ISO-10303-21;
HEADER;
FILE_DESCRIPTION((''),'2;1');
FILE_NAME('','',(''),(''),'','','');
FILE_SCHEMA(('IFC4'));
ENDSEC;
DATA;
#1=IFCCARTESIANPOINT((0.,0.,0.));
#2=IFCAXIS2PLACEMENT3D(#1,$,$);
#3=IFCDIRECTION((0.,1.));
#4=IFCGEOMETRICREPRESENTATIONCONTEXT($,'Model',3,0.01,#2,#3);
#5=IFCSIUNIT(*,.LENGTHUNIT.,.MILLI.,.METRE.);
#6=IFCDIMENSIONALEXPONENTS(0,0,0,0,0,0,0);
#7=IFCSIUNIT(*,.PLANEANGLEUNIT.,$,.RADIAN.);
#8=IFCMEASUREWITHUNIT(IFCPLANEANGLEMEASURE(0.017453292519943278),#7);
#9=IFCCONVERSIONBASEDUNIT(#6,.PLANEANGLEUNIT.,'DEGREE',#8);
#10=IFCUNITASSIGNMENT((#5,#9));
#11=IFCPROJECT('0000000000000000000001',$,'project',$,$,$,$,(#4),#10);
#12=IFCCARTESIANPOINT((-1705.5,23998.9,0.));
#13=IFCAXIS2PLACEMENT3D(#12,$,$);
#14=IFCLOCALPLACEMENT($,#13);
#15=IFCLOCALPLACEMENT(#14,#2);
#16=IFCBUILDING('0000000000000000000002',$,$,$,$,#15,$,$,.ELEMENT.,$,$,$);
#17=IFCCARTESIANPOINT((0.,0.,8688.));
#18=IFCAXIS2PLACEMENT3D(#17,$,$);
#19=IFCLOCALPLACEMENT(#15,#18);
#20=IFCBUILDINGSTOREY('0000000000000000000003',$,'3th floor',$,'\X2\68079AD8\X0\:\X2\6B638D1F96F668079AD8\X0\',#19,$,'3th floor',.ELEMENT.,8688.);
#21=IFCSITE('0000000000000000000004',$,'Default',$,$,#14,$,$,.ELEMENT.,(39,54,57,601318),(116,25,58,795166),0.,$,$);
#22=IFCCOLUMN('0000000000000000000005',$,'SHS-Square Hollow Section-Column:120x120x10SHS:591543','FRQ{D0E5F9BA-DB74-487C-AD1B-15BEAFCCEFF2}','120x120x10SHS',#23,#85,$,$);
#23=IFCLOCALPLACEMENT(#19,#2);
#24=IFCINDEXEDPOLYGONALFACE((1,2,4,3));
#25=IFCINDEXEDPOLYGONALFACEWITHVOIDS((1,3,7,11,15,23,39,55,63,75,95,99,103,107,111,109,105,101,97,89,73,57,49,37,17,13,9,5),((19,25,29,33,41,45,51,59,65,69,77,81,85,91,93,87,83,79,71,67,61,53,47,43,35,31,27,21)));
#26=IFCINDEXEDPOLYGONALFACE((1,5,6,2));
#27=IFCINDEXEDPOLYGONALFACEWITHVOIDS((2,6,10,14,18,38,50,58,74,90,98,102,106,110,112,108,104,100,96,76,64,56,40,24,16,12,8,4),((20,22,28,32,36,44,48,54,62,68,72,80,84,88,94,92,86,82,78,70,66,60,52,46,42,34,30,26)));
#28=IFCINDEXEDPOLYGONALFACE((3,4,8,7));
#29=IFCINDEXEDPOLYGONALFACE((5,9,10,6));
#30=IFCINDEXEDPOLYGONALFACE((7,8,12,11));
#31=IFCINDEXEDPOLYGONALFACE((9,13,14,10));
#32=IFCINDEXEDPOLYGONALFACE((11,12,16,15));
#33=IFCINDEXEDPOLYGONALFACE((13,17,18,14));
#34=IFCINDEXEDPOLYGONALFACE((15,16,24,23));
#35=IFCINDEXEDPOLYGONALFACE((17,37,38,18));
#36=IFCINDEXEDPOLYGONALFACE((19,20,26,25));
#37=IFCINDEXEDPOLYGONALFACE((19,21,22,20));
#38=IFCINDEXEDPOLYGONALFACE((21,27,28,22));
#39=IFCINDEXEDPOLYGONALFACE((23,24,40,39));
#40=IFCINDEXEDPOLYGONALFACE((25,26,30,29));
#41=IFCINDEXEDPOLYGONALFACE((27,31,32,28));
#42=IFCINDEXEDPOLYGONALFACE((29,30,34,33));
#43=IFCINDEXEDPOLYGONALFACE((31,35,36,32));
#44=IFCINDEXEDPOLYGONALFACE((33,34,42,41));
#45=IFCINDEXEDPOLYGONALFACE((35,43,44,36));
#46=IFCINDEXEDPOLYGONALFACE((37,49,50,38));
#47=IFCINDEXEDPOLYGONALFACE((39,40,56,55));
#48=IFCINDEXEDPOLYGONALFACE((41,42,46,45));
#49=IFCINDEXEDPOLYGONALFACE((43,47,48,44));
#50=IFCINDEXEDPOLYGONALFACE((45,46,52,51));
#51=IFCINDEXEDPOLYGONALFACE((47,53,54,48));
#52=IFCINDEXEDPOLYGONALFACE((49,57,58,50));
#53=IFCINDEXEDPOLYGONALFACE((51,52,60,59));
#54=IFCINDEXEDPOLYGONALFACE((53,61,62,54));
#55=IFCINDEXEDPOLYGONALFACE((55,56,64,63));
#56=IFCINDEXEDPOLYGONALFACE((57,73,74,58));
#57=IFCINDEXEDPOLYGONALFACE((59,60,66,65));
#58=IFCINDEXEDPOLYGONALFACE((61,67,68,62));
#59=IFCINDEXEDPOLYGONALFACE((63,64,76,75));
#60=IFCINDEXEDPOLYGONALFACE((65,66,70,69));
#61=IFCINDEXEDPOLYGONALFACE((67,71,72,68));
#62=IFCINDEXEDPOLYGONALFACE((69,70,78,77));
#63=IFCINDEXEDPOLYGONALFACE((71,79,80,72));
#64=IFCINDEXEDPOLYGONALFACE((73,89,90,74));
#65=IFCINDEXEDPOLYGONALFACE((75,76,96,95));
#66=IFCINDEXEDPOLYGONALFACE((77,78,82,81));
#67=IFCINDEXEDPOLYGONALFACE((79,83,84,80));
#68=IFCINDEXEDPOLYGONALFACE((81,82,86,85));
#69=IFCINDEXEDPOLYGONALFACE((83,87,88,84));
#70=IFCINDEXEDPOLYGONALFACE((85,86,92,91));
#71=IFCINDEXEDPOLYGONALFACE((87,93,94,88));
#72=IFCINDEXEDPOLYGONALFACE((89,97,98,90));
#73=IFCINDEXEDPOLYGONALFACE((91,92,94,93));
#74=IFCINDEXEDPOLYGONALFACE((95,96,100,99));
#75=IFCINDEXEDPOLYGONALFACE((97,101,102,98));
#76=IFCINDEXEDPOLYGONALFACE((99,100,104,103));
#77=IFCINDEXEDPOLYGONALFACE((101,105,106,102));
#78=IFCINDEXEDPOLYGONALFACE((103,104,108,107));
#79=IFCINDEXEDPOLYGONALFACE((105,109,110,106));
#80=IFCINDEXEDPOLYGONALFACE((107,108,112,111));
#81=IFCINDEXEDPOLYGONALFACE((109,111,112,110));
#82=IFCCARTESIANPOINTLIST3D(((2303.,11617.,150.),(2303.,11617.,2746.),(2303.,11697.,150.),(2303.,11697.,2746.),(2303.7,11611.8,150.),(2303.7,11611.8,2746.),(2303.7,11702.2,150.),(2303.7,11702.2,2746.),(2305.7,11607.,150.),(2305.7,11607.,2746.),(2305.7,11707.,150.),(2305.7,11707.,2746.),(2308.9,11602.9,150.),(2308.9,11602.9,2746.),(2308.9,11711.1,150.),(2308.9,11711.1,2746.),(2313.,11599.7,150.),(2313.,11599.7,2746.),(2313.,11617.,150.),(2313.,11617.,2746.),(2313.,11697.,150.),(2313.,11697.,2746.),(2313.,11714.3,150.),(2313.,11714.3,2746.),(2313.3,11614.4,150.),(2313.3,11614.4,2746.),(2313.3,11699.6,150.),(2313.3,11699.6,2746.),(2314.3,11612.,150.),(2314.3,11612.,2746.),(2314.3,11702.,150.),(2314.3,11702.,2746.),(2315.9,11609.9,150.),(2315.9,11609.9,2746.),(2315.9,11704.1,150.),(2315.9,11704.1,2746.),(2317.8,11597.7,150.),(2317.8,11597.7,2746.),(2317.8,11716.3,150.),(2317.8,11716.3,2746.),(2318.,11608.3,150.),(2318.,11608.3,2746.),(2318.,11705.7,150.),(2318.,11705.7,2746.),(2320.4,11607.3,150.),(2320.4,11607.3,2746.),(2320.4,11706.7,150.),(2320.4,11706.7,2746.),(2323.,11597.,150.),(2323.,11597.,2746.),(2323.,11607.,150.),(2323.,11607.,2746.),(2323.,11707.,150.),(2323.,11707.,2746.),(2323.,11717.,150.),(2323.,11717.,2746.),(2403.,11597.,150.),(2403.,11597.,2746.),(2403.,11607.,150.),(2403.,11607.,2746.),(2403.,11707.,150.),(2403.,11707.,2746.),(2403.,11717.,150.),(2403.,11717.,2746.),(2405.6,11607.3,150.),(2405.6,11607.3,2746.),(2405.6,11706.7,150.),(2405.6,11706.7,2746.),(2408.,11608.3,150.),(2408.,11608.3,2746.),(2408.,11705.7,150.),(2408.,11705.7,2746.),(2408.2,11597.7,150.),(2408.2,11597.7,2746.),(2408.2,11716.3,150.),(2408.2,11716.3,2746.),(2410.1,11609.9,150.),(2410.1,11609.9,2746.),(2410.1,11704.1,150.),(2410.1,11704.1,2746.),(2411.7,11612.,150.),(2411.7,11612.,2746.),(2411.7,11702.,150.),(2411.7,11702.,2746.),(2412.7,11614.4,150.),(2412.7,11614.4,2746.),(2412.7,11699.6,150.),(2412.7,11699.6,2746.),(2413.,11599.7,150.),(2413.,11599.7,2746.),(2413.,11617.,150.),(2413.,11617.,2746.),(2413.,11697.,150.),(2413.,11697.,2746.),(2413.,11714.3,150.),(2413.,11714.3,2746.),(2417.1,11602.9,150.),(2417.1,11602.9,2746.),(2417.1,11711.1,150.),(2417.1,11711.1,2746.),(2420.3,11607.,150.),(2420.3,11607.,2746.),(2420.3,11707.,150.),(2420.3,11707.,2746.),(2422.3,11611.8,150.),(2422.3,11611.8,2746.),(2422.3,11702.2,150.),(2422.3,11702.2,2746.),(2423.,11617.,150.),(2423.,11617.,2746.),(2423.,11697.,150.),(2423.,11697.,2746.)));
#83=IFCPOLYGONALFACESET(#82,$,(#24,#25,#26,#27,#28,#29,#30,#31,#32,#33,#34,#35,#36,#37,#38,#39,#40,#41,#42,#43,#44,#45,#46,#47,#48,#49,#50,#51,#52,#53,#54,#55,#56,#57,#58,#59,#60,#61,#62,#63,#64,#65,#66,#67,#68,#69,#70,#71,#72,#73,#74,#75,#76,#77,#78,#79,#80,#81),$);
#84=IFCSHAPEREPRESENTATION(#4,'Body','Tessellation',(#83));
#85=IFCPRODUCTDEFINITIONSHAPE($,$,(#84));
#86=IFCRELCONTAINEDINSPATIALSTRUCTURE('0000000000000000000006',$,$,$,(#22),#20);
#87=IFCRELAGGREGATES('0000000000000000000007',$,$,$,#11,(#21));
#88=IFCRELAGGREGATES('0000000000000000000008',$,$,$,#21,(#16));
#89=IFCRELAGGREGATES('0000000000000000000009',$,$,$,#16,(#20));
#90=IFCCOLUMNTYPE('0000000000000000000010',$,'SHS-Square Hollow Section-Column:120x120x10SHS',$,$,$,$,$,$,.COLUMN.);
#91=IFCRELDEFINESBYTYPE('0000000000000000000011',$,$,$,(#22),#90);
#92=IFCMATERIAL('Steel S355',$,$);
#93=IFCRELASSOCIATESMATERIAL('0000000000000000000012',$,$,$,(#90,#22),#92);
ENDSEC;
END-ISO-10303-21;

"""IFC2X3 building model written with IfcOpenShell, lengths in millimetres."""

from ifc_helpers import new_model, entity, si_unit, converted_unit, direction, frame, origin, origin_2d, place, context, project, spatial, hollow_rectangle, extrude, clip, halfspace, material, type_object, element, save


model = new_model("IFC2X3")

# Units and contexts
model_context = context("Model", 3, precision=0.01, world=origin(), true_north=direction((0.0, 1.0)))
ifc_project = project(units=[si_unit("LENGTHUNIT", "METRE", prefix="MILLI"), converted_unit("PLANEANGLEUNIT", "DEGREE", entity("IfcPlaneAngleMeasure", 0.017453292519943278), si_unit("PLANEANGLEUNIT", "RADIAN"), dimensions=[0, 0, 0, 0, 0, 0, 0])], contexts=[model_context])

# Site, building, storey
site_placement = place(None, frame((-1705.5, 23998.9, 0.0)))
site = spatial("IfcSite", under=ifc_project, at=site_placement, Name="Default", CompositionType="ELEMENT", RefLatitude=(39, 54, 57, 601318), RefLongitude=(116, 25, 58, 795166), RefElevation=0.0)
building_placement = place(site_placement, origin())
building = spatial("IfcBuilding", under=site, at=building_placement, CompositionType="ELEMENT")
storey_placement = place(building_placement, frame((0.0, 0.0, 8688.0)))
storey = spatial("IfcBuildingStorey", under=building, at=storey_placement, Name="3th floor", ObjectType="标高:正负零标高", LongName="3th floor", CompositionType="ELEMENT", Elevation=8688.0)

# Shared definitions
ifc_material_1 = material(Name="Steel S355")

# Column
column_type_1 = type_object("IfcColumnType", Name="SHS-Square Hollow Section-Column:120x120x10SHS", PredefinedType="COLUMN", material=ifc_material_1)
column_1_placement = place(storey_placement, frame((2363.0, 11657.0, 2830.9), z_axis=(0.0, 0.0, 1.0), x_axis=(0.0, -1.0, 0.0)))
element("IfcColumn", 1, at=column_1_placement, inside=storey, type_object=column_type_1, material=ifc_material_1, Name="SHS-Square Hollow Section-Column:120x120x10SHS:591543", Description="FRQ{D0E5F9BA-DB74-487C-AD1B-15BEAFCCEFF2}", ObjectType="120x120x10SHS", context=model_context, shape_type="Clipping", body=[
    clip(clip(extrude(hollow_rectangle(XDim=120.0, YDim=120.0, WallThickness=10.0, InnerFilletRadius=10.0, OuterFilletRadius=20.0, at=origin_2d()), origin(), (0.0, 0.0, -1.0), 2765.7), halfspace(frame((11657.0, -2363.0, -84.9), z_axis=(0.0, 0.0, -1.0), x_axis=(0.0, -1.0, 0.0)), True)), halfspace(frame((11657.0, -2363.0, -2680.9), z_axis=(0.0, 0.0, 1.0), x_axis=(0.0, 1.0, 0.0)), True)),
])

save(model, "model.ifc")
